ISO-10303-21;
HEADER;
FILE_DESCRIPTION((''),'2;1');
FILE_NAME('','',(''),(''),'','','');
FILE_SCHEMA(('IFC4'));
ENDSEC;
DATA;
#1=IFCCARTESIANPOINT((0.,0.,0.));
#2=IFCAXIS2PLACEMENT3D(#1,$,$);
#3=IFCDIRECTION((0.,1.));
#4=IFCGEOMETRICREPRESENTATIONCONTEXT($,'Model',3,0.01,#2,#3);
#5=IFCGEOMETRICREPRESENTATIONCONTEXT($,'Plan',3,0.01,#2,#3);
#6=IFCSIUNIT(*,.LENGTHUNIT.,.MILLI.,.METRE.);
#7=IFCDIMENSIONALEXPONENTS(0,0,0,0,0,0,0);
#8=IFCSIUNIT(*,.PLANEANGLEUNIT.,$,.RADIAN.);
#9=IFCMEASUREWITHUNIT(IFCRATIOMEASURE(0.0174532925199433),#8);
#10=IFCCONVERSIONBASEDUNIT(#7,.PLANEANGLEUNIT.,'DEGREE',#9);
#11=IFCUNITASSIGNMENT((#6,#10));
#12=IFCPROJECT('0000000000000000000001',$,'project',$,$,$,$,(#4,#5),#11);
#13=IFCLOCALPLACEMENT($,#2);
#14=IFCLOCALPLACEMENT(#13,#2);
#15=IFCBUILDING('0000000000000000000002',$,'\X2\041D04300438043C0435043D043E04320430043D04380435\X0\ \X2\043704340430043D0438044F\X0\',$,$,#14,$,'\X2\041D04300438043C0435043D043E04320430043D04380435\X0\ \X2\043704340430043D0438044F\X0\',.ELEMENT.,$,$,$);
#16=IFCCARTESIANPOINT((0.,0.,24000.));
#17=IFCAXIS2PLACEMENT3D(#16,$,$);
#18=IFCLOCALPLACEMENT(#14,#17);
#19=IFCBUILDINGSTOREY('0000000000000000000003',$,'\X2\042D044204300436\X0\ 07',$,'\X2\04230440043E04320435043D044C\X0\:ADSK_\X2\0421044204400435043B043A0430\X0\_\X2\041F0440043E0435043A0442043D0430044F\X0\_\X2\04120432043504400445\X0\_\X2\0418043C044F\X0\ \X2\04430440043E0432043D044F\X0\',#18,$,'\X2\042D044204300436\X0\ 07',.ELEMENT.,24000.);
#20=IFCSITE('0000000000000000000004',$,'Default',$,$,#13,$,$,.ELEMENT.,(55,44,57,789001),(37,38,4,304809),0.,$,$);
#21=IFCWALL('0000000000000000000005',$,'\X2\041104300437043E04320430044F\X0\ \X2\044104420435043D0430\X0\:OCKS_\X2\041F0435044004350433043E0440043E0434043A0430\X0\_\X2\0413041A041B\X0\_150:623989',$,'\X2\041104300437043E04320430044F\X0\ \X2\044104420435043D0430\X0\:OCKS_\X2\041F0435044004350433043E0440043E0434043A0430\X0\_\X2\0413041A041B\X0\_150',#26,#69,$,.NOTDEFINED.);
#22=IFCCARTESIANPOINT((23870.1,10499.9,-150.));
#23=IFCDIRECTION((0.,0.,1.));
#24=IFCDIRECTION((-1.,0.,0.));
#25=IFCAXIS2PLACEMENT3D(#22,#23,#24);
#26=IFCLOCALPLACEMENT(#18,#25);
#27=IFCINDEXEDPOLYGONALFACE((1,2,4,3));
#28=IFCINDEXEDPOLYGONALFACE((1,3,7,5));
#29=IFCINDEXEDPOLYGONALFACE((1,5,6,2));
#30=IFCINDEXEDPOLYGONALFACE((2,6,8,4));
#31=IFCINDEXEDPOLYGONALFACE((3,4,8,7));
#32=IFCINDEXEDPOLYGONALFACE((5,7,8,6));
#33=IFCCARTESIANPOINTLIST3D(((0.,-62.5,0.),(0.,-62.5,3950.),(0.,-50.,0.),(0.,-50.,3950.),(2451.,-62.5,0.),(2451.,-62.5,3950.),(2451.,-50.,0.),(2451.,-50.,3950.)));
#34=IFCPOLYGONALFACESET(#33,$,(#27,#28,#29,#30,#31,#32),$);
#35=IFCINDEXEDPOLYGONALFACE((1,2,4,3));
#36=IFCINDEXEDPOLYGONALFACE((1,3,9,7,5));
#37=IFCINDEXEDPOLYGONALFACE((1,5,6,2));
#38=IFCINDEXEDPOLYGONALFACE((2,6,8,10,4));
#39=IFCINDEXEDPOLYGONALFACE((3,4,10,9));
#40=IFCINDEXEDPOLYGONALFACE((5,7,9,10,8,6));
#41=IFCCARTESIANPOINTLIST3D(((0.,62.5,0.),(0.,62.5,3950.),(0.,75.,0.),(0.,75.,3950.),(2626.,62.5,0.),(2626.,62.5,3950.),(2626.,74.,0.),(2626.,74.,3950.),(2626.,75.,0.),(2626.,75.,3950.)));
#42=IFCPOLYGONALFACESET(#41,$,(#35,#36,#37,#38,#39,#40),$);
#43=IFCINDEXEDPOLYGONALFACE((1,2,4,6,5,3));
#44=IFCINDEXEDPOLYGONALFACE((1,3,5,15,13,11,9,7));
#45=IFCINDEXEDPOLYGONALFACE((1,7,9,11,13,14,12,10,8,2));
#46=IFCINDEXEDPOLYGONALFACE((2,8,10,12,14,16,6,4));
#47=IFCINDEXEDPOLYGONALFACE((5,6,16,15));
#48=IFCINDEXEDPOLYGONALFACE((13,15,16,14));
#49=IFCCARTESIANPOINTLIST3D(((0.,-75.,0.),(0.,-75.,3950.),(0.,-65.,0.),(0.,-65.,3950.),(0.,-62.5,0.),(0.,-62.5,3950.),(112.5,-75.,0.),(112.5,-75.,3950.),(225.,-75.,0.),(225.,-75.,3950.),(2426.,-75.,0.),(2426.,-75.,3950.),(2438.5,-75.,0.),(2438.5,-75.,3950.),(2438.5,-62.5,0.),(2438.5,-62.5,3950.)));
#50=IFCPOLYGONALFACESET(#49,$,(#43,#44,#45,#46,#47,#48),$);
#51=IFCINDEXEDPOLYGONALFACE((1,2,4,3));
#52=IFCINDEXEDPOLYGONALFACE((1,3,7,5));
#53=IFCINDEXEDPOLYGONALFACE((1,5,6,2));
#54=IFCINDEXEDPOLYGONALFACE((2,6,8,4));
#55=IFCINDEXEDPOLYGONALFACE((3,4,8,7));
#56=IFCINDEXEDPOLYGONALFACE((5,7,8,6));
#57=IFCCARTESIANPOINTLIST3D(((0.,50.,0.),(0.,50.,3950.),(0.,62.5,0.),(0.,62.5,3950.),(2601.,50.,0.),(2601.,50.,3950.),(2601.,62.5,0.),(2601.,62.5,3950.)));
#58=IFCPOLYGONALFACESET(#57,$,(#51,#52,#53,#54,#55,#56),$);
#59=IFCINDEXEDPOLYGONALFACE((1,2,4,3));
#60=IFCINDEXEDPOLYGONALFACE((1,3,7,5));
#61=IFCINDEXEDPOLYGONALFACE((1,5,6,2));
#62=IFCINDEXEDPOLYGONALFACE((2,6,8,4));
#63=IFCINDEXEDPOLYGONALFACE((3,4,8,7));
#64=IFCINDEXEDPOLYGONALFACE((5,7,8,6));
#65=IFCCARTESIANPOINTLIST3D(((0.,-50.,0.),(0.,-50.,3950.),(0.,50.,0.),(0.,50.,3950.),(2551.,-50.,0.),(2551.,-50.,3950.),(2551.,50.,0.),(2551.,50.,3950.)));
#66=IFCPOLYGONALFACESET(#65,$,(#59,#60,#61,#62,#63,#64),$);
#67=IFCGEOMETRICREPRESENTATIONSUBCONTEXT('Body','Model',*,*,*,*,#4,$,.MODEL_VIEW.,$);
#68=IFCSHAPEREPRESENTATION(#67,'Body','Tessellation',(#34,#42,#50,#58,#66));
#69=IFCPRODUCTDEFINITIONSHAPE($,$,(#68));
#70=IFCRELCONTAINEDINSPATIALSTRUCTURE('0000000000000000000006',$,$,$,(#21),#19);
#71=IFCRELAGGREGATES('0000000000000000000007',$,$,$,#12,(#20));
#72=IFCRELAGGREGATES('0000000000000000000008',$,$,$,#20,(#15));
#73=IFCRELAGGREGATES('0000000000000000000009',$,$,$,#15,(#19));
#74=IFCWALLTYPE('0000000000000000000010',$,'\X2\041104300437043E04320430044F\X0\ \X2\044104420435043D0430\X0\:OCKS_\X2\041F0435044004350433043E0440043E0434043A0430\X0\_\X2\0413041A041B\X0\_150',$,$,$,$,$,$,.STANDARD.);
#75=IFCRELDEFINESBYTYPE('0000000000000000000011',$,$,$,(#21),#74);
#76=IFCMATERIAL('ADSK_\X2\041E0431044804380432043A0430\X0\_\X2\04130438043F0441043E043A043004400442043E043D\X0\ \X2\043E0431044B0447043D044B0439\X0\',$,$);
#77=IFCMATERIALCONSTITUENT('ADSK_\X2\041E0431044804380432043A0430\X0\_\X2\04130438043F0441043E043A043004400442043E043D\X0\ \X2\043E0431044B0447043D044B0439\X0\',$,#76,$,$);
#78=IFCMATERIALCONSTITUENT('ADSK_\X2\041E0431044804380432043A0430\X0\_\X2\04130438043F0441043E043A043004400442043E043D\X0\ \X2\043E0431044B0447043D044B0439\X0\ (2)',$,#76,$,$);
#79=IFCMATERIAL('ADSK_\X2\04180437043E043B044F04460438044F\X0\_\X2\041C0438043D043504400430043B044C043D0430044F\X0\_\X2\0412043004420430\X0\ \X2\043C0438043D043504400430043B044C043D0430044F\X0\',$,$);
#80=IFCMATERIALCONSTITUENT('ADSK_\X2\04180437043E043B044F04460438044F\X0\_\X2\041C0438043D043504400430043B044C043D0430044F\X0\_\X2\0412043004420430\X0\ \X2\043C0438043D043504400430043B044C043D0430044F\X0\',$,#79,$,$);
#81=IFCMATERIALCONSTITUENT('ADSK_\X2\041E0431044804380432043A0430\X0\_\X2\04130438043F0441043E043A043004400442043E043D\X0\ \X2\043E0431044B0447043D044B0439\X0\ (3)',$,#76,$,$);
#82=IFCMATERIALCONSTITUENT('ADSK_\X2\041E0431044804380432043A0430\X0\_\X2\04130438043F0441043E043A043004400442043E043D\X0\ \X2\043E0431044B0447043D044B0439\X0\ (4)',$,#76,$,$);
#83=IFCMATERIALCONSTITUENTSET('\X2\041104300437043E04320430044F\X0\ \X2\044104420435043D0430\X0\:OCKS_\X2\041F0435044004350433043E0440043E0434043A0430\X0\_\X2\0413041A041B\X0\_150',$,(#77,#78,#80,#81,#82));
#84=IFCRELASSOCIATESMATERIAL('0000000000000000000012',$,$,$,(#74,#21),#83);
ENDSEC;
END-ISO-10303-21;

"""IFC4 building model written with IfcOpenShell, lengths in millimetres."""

from ifc_helpers import new_model, entity, si_unit, converted_unit, direction, frame, origin, place, context, subcontext, project, spatial, indexed_curve, outline, extrude, material, constituent, constituent_set, type_object, element, save


model = new_model("IFC4")

# Units and contexts
model_context = context("Model", 3, precision=0.01, world=origin(), true_north=direction((0.0, 1.0)))
plan_context = context("Plan", 3, precision=0.01, world=origin(), true_north=direction((0.0, 1.0)))
body_context = subcontext(model_context, "Body", "Model", "MODEL_VIEW")
ifc_project = project(units=[si_unit("LENGTHUNIT", "METRE", prefix="MILLI"), converted_unit("PLANEANGLEUNIT", "DEGREE", entity("IfcRatioMeasure", 0.0174532925199433), si_unit("PLANEANGLEUNIT", "RADIAN"), dimensions=[0, 0, 0, 0, 0, 0, 0])], contexts=[model_context, plan_context])

# Site, building, storey
site_placement = place(None, frame((0.0, 0.0, 0.0)))
site = spatial("IfcSite", under=ifc_project, at=site_placement, Name="Default", CompositionType="ELEMENT", RefLatitude=(55, 44, 57, 789001), RefLongitude=(37, 38, 4, 304809), RefElevation=0.0)
building_placement = place(site_placement, origin())
building = spatial("IfcBuilding", under=site, at=building_placement, Name="Наименование здания", LongName="Наименование здания", CompositionType="ELEMENT")
storey_placement = place(building_placement, frame((0.0, 0.0, 24000.0)))
storey = spatial("IfcBuildingStorey", under=building, at=storey_placement, Name="Этаж 07", ObjectType="Уровень:ADSK_Стрелка_Проектная_Вверх_Имя уровня", LongName="Этаж 07", CompositionType="ELEMENT", Elevation=24000.0)

# Shared definitions
ifc_material_1 = material(Name="ADSK_Обшивка_Гипсокартон обычный")
ifc_constituent_1 = constituent(ifc_material_1, Name="ADSK_Обшивка_Гипсокартон обычный")
ifc_constituent_2 = constituent(ifc_material_1, Name="ADSK_Обшивка_Гипсокартон обычный (2)")
ifc_material_2 = material(Name="ADSK_Изоляция_Минеральная_Вата минеральная")
ifc_constituent_3 = constituent(ifc_material_2, Name="ADSK_Изоляция_Минеральная_Вата минеральная")
ifc_constituent_4 = constituent(ifc_material_1, Name="ADSK_Обшивка_Гипсокартон обычный (3)")
ifc_constituent_5 = constituent(ifc_material_1, Name="ADSK_Обшивка_Гипсокартон обычный (4)")
ifc_constituent_set_1 = constituent_set(constituents=[ifc_constituent_1, ifc_constituent_2, ifc_constituent_3, ifc_constituent_4, ifc_constituent_5], Name="Базовая стена:OCKS_Перегородка_ГКЛ_150")
wall_type_1 = type_object("IfcWallType", Name="Базовая стена:OCKS_Перегородка_ГКЛ_150", PredefinedType="STANDARD", material=ifc_constituent_set_1)

# Wall
wall_1_placement = place(storey_placement, frame((23870.1, 10499.9, -150.0), z_axis=(0.0, 0.0, 1.0), x_axis=(-1.0, 0.0, 0.0)))
element("IfcWall", 1, at=wall_1_placement, inside=storey, type_object=wall_type_1, material=ifc_constituent_set_1, Name="Базовая стена:OCKS_Перегородка_ГКЛ_150:623989", ObjectType="Базовая стена:OCKS_Перегородка_ГКЛ_150", PredefinedType="NOTDEFINED", context=body_context, shape_type="SweptSolid", body=[
    extrude(outline(indexed_curve([(-1225.5, -6.3), (1225.5, -6.3), (1225.5, 6.3), (-1225.5, 6.3), (-1225.5, -6.3)], self_intersect=False)), frame((1225.5, -56.3, 0.0)), (0.0, 0.0, 1.0), 3950.0),
    extrude(outline(indexed_curve([(-5.2, -1575.6), (7.3, -1575.6), (7.3, 1050.4), (-4.2, 1050.4), (-5.2, 1050.4), (-5.2, -1575.6)], self_intersect=False)), frame((1575.6, 69.8, 0.0), z_axis=(0.0, 0.0, 1.0), x_axis=(0.0, -1.0, 0.0)), (0.0, 0.0, 1.0), 3950.0),
    extrude(outline(indexed_curve([(-842.6, -4.4), (-730.1, -4.4), (1470.9, -4.4), (1483.4, -4.4), (1483.4, 8.1), (-955.1, 8.1), (-955.1, 5.6), (-955.1, -4.4), (-842.6, -4.4)], self_intersect=False)), frame((955.1, -70.6, 0.0)), (0.0, 0.0, 1.0), 3950.0),
    extrude(outline(indexed_curve([(-1300.5, -6.3), (1300.5, -6.3), (1300.5, 6.3), (-1300.5, 6.3), (-1300.5, -6.3)], self_intersect=False)), frame((1300.5, 56.2, 0.0)), (0.0, 0.0, 1.0), 3950.0),
    extrude(outline(indexed_curve([(-1275.5, -50.0), (1275.5, -50.0), (1275.5, 50.0), (-1275.5, 50.0), (-1275.5, -50.0)], self_intersect=False)), frame((1275.5, 0.0, 0.0)), (0.0, 0.0, 1.0), 3950.0),
])

save(model, "model.ifc")
